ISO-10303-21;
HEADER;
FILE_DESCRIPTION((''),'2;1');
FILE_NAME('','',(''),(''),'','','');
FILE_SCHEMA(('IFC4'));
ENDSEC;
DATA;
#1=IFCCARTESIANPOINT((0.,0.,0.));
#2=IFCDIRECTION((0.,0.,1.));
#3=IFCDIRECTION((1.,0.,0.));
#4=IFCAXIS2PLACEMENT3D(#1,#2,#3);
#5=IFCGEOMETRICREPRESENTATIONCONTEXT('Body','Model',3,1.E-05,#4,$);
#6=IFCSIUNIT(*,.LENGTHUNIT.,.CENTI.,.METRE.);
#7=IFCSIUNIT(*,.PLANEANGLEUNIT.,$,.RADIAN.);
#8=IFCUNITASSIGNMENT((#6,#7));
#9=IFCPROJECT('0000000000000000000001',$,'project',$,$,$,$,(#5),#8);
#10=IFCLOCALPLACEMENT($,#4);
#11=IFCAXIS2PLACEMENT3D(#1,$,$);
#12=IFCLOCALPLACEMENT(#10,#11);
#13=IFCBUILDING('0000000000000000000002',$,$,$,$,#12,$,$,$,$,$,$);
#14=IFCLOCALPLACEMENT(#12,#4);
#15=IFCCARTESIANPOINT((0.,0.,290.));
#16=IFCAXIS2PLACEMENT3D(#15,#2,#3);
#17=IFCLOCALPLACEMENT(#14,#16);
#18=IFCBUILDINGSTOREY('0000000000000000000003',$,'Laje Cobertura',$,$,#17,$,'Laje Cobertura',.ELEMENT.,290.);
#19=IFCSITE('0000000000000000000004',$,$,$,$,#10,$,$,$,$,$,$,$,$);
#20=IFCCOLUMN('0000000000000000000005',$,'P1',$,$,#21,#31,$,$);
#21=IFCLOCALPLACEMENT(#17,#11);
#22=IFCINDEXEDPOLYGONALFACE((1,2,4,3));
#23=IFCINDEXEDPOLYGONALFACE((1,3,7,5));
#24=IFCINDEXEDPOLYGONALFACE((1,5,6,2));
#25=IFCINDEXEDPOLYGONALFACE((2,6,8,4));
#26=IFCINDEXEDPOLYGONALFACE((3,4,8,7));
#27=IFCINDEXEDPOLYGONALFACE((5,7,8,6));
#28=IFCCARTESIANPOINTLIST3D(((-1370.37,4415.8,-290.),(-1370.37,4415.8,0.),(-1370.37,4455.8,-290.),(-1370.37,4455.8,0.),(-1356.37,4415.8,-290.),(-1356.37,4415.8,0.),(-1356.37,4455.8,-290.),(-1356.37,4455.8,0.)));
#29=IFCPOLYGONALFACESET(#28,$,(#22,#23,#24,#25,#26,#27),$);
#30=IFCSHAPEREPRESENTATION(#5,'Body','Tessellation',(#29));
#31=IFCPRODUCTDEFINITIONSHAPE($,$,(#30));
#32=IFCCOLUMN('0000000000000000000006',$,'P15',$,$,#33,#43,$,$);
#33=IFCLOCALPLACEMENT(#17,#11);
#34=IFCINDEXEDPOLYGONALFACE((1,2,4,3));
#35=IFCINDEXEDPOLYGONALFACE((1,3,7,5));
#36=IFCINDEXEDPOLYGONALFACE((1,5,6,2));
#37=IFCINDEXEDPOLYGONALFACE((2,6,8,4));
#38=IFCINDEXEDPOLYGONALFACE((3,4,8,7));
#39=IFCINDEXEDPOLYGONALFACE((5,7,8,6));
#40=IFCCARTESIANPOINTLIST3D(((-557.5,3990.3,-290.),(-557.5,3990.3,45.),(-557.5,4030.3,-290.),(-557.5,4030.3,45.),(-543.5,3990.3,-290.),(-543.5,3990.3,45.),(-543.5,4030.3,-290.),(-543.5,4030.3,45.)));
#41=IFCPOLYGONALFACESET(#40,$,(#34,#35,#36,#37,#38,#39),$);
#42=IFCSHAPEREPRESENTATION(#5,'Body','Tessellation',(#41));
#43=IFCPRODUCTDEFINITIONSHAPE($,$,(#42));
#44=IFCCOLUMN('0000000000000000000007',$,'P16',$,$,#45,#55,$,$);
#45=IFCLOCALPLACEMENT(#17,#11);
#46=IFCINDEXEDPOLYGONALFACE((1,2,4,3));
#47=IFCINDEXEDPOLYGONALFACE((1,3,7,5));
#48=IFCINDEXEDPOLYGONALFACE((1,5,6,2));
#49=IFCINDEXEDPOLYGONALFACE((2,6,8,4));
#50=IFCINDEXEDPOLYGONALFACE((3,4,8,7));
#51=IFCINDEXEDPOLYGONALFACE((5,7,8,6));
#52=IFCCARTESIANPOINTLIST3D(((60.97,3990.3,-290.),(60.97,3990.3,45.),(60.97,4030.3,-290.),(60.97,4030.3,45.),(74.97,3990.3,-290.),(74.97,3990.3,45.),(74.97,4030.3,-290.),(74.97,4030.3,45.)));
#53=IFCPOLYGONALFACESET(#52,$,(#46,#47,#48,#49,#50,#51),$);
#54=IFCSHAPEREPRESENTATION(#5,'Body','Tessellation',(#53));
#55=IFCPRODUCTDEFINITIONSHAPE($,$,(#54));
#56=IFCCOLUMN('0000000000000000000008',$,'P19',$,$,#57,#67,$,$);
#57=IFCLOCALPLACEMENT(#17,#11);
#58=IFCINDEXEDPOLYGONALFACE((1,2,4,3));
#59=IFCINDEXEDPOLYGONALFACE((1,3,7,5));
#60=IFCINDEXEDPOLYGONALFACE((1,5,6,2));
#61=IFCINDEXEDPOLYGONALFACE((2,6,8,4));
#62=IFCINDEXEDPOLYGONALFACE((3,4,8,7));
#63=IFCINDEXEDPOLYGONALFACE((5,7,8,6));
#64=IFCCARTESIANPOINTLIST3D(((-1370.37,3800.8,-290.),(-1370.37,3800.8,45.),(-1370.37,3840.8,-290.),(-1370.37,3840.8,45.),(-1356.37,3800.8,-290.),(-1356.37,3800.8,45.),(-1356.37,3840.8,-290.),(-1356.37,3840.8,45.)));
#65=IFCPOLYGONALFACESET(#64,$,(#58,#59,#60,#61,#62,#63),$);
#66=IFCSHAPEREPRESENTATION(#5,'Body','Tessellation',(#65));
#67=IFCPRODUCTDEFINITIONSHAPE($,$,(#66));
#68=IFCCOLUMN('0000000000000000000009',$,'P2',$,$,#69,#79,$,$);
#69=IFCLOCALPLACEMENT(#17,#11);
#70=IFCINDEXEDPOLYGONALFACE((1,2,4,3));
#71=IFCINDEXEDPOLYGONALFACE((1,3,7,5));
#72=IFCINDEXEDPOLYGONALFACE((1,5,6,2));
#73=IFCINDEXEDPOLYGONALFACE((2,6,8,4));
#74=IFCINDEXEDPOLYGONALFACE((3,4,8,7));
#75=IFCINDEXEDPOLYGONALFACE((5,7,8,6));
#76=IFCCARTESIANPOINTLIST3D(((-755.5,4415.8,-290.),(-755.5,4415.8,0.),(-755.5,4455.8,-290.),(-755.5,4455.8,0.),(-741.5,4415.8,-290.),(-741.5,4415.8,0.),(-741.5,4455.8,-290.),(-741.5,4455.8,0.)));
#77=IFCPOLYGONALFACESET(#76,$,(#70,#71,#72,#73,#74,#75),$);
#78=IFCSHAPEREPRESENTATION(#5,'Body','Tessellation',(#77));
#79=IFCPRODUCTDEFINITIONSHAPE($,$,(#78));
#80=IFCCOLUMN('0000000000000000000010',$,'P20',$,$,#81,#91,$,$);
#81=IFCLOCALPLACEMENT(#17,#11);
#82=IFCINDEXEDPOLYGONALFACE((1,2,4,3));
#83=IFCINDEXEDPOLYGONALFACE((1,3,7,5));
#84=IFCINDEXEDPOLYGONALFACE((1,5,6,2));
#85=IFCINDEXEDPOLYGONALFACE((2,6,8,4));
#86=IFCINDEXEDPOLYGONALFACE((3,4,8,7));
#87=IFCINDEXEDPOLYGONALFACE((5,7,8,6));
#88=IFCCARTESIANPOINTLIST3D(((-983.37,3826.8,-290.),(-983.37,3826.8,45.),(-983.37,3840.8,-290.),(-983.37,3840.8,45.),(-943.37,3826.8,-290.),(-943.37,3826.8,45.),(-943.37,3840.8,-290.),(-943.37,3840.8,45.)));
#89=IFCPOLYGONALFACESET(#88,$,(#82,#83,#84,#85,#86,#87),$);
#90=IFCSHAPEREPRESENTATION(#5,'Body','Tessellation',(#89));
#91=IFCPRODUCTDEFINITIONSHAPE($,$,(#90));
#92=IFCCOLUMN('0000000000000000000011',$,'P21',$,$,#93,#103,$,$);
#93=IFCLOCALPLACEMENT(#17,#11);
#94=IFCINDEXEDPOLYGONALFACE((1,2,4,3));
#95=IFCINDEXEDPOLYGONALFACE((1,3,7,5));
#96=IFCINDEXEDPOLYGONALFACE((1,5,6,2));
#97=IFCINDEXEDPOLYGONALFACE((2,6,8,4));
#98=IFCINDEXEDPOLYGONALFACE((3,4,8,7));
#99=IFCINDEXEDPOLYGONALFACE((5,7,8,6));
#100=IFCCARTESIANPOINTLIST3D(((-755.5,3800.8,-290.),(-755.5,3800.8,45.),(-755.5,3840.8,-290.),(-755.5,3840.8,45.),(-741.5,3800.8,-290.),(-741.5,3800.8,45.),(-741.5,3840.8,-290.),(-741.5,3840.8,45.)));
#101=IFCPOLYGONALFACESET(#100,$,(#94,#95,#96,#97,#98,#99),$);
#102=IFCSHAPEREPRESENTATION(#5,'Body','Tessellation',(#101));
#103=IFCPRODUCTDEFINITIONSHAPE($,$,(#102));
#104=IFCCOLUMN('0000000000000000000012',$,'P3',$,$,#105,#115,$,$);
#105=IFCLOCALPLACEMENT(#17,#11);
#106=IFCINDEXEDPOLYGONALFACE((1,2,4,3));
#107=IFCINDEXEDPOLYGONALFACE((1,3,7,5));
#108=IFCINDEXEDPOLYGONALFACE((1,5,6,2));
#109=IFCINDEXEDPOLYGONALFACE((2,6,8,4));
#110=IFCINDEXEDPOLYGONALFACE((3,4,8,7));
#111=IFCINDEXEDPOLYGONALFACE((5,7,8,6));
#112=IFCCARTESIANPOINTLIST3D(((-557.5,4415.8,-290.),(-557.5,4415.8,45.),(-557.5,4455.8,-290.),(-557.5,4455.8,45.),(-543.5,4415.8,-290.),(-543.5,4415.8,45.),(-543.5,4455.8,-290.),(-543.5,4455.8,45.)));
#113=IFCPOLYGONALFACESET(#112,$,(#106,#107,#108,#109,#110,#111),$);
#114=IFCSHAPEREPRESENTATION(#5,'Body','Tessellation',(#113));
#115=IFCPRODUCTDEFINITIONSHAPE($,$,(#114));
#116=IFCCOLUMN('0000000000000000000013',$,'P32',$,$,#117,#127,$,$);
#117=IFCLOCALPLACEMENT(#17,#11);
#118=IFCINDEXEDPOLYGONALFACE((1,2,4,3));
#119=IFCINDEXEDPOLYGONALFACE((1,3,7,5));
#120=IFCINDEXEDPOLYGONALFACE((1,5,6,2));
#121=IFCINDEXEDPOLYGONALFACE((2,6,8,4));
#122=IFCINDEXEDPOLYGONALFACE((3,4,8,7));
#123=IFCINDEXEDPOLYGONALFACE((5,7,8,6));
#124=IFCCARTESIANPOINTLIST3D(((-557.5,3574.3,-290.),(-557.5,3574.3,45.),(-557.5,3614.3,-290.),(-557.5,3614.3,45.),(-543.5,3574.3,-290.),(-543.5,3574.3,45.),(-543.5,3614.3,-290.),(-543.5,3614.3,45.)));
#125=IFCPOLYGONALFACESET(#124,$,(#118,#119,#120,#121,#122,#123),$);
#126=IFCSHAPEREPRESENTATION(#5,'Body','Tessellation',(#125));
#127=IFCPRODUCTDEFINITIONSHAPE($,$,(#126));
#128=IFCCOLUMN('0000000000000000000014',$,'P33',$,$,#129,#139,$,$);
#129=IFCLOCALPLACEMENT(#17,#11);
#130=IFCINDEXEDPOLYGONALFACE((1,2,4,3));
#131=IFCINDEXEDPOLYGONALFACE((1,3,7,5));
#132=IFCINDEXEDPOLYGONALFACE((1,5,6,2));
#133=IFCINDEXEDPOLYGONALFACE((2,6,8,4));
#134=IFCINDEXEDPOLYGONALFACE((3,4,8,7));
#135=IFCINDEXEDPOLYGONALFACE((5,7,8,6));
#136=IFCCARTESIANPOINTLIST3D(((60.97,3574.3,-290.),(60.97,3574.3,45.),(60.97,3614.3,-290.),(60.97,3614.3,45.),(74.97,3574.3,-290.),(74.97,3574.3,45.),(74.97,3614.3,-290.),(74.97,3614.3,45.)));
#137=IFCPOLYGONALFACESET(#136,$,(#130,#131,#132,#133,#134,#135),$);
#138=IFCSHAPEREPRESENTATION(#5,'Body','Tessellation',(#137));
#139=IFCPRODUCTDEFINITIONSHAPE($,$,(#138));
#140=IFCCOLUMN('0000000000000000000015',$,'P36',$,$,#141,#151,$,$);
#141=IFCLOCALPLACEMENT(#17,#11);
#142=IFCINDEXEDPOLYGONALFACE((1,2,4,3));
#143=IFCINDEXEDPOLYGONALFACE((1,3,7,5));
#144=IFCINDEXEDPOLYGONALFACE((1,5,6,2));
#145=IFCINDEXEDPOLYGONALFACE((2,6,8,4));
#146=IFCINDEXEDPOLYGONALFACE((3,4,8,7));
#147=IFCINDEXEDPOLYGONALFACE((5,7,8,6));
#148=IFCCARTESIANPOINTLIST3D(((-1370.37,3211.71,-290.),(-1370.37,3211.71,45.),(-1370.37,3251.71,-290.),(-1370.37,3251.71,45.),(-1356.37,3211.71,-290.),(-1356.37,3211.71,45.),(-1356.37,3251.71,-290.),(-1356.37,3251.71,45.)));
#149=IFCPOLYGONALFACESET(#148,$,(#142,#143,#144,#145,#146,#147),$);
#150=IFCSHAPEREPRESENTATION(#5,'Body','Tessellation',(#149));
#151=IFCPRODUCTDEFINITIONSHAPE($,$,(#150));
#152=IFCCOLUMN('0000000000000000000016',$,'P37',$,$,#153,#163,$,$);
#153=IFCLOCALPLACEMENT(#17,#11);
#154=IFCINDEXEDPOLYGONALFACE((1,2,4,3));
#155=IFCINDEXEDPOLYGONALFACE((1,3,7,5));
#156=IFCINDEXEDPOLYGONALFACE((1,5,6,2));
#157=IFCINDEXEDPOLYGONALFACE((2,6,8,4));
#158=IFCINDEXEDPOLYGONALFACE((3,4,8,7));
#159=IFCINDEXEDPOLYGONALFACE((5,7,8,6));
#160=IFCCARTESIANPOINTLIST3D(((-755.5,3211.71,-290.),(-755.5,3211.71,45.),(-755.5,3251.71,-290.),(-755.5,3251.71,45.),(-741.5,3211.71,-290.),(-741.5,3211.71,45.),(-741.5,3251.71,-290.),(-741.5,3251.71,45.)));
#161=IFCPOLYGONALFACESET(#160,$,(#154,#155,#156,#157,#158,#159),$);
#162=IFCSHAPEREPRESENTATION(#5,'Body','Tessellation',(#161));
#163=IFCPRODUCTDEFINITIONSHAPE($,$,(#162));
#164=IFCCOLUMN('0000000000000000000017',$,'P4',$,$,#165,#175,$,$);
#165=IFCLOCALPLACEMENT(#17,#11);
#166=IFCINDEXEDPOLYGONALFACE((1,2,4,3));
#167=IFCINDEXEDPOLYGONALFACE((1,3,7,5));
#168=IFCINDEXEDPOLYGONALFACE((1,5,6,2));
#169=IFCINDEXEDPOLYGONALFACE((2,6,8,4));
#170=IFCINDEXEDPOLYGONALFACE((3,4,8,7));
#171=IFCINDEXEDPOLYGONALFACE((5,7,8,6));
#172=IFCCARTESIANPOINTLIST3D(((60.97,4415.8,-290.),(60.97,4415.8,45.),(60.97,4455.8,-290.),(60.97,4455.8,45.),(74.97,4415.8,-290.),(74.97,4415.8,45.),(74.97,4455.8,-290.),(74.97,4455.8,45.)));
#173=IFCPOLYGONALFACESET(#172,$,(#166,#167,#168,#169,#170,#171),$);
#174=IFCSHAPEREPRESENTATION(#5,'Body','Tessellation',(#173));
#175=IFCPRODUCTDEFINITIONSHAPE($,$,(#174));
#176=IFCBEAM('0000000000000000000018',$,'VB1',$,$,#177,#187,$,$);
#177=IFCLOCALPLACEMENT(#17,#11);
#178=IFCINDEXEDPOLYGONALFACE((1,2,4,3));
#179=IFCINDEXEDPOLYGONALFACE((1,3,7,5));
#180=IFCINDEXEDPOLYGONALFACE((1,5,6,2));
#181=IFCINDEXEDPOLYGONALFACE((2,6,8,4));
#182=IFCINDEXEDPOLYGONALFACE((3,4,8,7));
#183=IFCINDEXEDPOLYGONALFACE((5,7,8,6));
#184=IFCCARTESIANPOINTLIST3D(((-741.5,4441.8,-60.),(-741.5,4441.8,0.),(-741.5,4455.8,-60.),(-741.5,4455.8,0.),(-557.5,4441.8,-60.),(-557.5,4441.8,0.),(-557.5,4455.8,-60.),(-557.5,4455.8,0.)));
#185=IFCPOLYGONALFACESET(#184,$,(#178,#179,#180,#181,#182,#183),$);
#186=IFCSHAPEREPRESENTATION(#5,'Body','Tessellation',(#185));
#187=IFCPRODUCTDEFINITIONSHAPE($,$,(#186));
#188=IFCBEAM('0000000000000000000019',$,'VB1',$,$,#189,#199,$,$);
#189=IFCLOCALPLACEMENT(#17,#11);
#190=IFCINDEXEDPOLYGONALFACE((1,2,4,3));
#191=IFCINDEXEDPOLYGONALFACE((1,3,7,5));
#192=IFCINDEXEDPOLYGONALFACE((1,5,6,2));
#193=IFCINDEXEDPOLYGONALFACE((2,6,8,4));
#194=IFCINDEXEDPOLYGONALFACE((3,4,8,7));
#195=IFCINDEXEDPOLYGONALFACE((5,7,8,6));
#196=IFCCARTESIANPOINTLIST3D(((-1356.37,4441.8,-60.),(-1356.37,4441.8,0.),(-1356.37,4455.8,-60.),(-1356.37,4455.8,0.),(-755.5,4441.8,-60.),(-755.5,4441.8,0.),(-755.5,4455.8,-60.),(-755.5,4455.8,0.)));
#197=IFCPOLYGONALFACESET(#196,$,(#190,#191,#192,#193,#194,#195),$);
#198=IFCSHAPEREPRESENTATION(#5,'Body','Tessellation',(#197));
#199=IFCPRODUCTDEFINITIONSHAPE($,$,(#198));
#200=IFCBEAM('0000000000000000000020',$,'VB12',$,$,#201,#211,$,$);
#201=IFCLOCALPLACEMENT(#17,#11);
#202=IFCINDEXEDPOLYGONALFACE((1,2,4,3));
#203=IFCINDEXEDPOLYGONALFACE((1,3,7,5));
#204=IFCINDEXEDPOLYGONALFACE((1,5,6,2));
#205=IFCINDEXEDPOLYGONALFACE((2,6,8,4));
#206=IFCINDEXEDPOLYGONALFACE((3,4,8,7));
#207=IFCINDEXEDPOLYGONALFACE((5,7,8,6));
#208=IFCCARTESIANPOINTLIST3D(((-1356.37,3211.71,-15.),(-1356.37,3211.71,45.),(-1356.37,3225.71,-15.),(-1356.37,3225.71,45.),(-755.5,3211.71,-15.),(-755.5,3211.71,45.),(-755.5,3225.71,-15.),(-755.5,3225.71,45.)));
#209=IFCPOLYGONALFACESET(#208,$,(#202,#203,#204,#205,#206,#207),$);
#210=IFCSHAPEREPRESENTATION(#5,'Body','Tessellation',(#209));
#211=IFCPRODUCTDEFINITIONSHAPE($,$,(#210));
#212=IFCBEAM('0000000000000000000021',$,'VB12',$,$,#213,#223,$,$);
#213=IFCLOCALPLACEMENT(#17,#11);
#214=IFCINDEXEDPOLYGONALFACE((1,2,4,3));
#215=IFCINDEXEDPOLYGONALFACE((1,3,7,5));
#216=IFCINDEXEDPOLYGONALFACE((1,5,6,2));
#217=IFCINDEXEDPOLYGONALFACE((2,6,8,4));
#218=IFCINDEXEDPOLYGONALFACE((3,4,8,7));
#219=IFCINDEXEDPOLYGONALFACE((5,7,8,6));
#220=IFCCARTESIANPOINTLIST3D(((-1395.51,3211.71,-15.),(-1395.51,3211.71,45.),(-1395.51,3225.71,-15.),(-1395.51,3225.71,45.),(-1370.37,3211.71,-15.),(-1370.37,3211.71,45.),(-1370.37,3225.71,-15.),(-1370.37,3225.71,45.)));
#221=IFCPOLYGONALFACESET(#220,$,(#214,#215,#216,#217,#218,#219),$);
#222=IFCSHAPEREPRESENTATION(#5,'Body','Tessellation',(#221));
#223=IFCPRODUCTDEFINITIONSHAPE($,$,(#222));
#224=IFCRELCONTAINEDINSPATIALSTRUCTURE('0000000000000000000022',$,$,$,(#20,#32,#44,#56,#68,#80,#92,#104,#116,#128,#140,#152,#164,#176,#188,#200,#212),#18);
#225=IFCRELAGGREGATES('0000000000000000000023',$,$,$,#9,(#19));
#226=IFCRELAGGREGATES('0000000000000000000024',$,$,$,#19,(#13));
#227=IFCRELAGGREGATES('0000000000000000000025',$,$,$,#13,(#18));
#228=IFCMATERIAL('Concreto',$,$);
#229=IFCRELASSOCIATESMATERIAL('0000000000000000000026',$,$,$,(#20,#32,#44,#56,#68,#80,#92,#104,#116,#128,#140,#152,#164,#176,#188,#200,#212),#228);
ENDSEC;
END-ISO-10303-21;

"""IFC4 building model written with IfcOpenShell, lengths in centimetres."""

from ifc_helpers import new_model, si_unit, frame, origin, origin_with_axes, origin_2d_with_axis, place, context, project, spatial, rectangle, extrude, material, element, save


model = new_model("IFC4")

# Units and contexts
model_context = context("Model", 3, precision=1e-05, world=origin_with_axes(), identifier="Body")
ifc_project = project(units=[si_unit("LENGTHUNIT", "METRE", prefix="CENTI"), si_unit("PLANEANGLEUNIT", "RADIAN")], contexts=[model_context])

# Site, building, storey
site_placement = place(None, origin_with_axes())
site = spatial("IfcSite", under=ifc_project, at=site_placement)
building_placement = place(site_placement, origin())
building = spatial("IfcBuilding", under=site, at=building_placement)
placement = place(building_placement, origin_with_axes())
storey_placement = place(placement, frame((0.0, 0.0, 290.0), z_axis=(0.0, 0.0, 1.0), x_axis=(1.0, 0.0, 0.0)))
storey = spatial("IfcBuildingStorey", under=building, at=storey_placement, Name="Laje Cobertura", LongName="Laje Cobertura", CompositionType="ELEMENT", Elevation=290.0)

# Columns
ifc_material = material(Name="Concreto")
column_1_placement = place(storey_placement, frame((-1363.37, 4435.8, 0.0), z_axis=(0.0, 0.0, 1.0), x_axis=(1.0, 0.0, 0.0)))
element("IfcColumn", 1, at=column_1_placement, inside=storey, material=ifc_material, Name="P1", context=model_context, shape_type="SolidModel", body=[
    extrude(rectangle(XDim=14.0, YDim=40.0, at=origin_2d_with_axis()), origin_with_axes(), (0.0, 0.0, -1.0), 290.0),
])
for number, where, z_axis, x_axis, name in (
    (2, (-550.5, 4010.3, 45.0), (0.0, 0.0, 1.0), (1.0, 0.0, 0.0), "P15"),
    (3, (67.97, 4010.3, 45.0), (0.0, 0.0, 1.0), (1.0, 0.0, 0.0), "P16"),
    (4, (-1363.37, 3820.8, 45.0), (0.0, 0.0, 1.0), (1.0, 0.0, 0.0), "P19"),
):
    element("IfcColumn", number, at=place(storey_placement, frame(where, z_axis=z_axis, x_axis=x_axis)), inside=storey, material=ifc_material, Name=name, context=model_context, shape_type="SolidModel", body=[
        extrude(rectangle(XDim=14.0, YDim=40.0, at=origin_2d_with_axis()), origin_with_axes(), (0.0, 0.0, -1.0), 335.0),
    ])
column_2_placement = place(storey_placement, frame((-748.5, 4435.8, 0.0), z_axis=(0.0, 0.0, 1.0), x_axis=(1.0, 0.0, 0.0)))
element("IfcColumn", 5, at=column_2_placement, inside=storey, material=ifc_material, Name="P2", context=model_context, shape_type="SolidModel", body=[
    extrude(rectangle(XDim=14.0, YDim=40.0, at=origin_2d_with_axis()), origin_with_axes(), (0.0, 0.0, -1.0), 290.0),
])
column_3_placement = place(storey_placement, frame((-963.37, 3833.8, 45.0), z_axis=(0.0, 0.0, 1.0), x_axis=(1.0, 0.0, 0.0)))
element("IfcColumn", 6, at=column_3_placement, inside=storey, material=ifc_material, Name="P20", context=model_context, shape_type="SolidModel", body=[
    extrude(rectangle(XDim=14.0, YDim=40.0, at=origin_2d_with_axis()), frame((0.0, 0.0, 0.0), z_axis=(0.0, 0.0, 1.0), x_axis=(0.0, -1.0, 0.0)), (0.0, 0.0, -1.0), 335.0),
])
for number, where, z_axis, x_axis, name in (
    (7, (-748.5, 3820.8, 45.0), (0.0, 0.0, 1.0), (1.0, 0.0, 0.0), "P21"),
    (8, (-550.5, 4435.8, 45.0), (0.0, 0.0, 1.0), (1.0, 0.0, 0.0), "P3"),
    (9, (-550.5, 3594.3, 45.0), (0.0, 0.0, 1.0), (1.0, 0.0, 0.0), "P32"),
    (10, (67.97, 3594.3, 45.0), (0.0, 0.0, 1.0), (1.0, 0.0, 0.0), "P33"),
    (11, (-1363.37, 3231.71, 45.0), (0.0, 0.0, 1.0), (1.0, 0.0, 0.0), "P36"),
    (12, (-748.5, 3231.71, 45.0), (0.0, 0.0, 1.0), (1.0, 0.0, 0.0), "P37"),
    (13, (67.97, 4435.8, 45.0), (0.0, 0.0, 1.0), (1.0, 0.0, 0.0), "P4"),
):
    element("IfcColumn", number, at=place(storey_placement, frame(where, z_axis=z_axis, x_axis=x_axis)), inside=storey, material=ifc_material, Name=name, context=model_context, shape_type="SolidModel", body=[
        extrude(rectangle(XDim=14.0, YDim=40.0, at=origin_2d_with_axis()), origin_with_axes(), (0.0, 0.0, -1.0), 335.0),
    ])

# Beams
beam_1_placement = place(storey_placement, frame((-649.5, 4448.8, 0.0), z_axis=(0.0, 0.0, 1.0), x_axis=(1.0, 0.0, 0.0)))
element("IfcBeam", 14, at=beam_1_placement, inside=storey, material=ifc_material, Name="VB1", context=model_context, shape_type="SolidModel", body=[
    extrude(rectangle(XDim=14.0, YDim=60.0, at=origin_2d_with_axis()), frame((-92.0, 0.0, -30.0), z_axis=(1.0, 0.0, 0.0), x_axis=(0.0, 1.0, 0.0)), (0.0, 0.0, 1.0), 184.0),
])
for number, where, z_axis, x_axis, name in (
    (15, (-1055.93, 4448.8, 0.0), (0.0, 0.0, 1.0), (1.0, 0.0, 0.0), "VB1"),
    (16, (-1055.93, 3218.71, 45.0), (0.0, 0.0, 1.0), (1.0, 0.0, 0.0), "VB12"),
):
    element("IfcBeam", number, at=place(storey_placement, frame(where, z_axis=z_axis, x_axis=x_axis)), inside=storey, material=ifc_material, Name=name, context=model_context, shape_type="SolidModel", body=[
        extrude(rectangle(XDim=14.0, YDim=60.0, at=origin_2d_with_axis()), frame((-300.44, 0.0, -30.0), z_axis=(1.0, 0.0, 0.0), x_axis=(0.0, 1.0, 0.0)), (0.0, 0.0, 1.0), 600.87),
    ])
beam_2_placement = place(storey_placement, frame((-1382.94, 3218.71, 45.0), z_axis=(0.0, 0.0, 1.0), x_axis=(1.0, 0.0, 0.0)))
element("IfcBeam", 17, at=beam_2_placement, inside=storey, material=ifc_material, Name="VB12", context=model_context, shape_type="SolidModel", body=[
    extrude(rectangle(XDim=14.0, YDim=60.0, at=origin_2d_with_axis()), frame((-12.57, 0.0, -30.0), z_axis=(1.0, 0.0, 0.0), x_axis=(0.0, 1.0, 0.0)), (0.0, 0.0, 1.0), 25.14),
])

save(model, "model.ifc")
